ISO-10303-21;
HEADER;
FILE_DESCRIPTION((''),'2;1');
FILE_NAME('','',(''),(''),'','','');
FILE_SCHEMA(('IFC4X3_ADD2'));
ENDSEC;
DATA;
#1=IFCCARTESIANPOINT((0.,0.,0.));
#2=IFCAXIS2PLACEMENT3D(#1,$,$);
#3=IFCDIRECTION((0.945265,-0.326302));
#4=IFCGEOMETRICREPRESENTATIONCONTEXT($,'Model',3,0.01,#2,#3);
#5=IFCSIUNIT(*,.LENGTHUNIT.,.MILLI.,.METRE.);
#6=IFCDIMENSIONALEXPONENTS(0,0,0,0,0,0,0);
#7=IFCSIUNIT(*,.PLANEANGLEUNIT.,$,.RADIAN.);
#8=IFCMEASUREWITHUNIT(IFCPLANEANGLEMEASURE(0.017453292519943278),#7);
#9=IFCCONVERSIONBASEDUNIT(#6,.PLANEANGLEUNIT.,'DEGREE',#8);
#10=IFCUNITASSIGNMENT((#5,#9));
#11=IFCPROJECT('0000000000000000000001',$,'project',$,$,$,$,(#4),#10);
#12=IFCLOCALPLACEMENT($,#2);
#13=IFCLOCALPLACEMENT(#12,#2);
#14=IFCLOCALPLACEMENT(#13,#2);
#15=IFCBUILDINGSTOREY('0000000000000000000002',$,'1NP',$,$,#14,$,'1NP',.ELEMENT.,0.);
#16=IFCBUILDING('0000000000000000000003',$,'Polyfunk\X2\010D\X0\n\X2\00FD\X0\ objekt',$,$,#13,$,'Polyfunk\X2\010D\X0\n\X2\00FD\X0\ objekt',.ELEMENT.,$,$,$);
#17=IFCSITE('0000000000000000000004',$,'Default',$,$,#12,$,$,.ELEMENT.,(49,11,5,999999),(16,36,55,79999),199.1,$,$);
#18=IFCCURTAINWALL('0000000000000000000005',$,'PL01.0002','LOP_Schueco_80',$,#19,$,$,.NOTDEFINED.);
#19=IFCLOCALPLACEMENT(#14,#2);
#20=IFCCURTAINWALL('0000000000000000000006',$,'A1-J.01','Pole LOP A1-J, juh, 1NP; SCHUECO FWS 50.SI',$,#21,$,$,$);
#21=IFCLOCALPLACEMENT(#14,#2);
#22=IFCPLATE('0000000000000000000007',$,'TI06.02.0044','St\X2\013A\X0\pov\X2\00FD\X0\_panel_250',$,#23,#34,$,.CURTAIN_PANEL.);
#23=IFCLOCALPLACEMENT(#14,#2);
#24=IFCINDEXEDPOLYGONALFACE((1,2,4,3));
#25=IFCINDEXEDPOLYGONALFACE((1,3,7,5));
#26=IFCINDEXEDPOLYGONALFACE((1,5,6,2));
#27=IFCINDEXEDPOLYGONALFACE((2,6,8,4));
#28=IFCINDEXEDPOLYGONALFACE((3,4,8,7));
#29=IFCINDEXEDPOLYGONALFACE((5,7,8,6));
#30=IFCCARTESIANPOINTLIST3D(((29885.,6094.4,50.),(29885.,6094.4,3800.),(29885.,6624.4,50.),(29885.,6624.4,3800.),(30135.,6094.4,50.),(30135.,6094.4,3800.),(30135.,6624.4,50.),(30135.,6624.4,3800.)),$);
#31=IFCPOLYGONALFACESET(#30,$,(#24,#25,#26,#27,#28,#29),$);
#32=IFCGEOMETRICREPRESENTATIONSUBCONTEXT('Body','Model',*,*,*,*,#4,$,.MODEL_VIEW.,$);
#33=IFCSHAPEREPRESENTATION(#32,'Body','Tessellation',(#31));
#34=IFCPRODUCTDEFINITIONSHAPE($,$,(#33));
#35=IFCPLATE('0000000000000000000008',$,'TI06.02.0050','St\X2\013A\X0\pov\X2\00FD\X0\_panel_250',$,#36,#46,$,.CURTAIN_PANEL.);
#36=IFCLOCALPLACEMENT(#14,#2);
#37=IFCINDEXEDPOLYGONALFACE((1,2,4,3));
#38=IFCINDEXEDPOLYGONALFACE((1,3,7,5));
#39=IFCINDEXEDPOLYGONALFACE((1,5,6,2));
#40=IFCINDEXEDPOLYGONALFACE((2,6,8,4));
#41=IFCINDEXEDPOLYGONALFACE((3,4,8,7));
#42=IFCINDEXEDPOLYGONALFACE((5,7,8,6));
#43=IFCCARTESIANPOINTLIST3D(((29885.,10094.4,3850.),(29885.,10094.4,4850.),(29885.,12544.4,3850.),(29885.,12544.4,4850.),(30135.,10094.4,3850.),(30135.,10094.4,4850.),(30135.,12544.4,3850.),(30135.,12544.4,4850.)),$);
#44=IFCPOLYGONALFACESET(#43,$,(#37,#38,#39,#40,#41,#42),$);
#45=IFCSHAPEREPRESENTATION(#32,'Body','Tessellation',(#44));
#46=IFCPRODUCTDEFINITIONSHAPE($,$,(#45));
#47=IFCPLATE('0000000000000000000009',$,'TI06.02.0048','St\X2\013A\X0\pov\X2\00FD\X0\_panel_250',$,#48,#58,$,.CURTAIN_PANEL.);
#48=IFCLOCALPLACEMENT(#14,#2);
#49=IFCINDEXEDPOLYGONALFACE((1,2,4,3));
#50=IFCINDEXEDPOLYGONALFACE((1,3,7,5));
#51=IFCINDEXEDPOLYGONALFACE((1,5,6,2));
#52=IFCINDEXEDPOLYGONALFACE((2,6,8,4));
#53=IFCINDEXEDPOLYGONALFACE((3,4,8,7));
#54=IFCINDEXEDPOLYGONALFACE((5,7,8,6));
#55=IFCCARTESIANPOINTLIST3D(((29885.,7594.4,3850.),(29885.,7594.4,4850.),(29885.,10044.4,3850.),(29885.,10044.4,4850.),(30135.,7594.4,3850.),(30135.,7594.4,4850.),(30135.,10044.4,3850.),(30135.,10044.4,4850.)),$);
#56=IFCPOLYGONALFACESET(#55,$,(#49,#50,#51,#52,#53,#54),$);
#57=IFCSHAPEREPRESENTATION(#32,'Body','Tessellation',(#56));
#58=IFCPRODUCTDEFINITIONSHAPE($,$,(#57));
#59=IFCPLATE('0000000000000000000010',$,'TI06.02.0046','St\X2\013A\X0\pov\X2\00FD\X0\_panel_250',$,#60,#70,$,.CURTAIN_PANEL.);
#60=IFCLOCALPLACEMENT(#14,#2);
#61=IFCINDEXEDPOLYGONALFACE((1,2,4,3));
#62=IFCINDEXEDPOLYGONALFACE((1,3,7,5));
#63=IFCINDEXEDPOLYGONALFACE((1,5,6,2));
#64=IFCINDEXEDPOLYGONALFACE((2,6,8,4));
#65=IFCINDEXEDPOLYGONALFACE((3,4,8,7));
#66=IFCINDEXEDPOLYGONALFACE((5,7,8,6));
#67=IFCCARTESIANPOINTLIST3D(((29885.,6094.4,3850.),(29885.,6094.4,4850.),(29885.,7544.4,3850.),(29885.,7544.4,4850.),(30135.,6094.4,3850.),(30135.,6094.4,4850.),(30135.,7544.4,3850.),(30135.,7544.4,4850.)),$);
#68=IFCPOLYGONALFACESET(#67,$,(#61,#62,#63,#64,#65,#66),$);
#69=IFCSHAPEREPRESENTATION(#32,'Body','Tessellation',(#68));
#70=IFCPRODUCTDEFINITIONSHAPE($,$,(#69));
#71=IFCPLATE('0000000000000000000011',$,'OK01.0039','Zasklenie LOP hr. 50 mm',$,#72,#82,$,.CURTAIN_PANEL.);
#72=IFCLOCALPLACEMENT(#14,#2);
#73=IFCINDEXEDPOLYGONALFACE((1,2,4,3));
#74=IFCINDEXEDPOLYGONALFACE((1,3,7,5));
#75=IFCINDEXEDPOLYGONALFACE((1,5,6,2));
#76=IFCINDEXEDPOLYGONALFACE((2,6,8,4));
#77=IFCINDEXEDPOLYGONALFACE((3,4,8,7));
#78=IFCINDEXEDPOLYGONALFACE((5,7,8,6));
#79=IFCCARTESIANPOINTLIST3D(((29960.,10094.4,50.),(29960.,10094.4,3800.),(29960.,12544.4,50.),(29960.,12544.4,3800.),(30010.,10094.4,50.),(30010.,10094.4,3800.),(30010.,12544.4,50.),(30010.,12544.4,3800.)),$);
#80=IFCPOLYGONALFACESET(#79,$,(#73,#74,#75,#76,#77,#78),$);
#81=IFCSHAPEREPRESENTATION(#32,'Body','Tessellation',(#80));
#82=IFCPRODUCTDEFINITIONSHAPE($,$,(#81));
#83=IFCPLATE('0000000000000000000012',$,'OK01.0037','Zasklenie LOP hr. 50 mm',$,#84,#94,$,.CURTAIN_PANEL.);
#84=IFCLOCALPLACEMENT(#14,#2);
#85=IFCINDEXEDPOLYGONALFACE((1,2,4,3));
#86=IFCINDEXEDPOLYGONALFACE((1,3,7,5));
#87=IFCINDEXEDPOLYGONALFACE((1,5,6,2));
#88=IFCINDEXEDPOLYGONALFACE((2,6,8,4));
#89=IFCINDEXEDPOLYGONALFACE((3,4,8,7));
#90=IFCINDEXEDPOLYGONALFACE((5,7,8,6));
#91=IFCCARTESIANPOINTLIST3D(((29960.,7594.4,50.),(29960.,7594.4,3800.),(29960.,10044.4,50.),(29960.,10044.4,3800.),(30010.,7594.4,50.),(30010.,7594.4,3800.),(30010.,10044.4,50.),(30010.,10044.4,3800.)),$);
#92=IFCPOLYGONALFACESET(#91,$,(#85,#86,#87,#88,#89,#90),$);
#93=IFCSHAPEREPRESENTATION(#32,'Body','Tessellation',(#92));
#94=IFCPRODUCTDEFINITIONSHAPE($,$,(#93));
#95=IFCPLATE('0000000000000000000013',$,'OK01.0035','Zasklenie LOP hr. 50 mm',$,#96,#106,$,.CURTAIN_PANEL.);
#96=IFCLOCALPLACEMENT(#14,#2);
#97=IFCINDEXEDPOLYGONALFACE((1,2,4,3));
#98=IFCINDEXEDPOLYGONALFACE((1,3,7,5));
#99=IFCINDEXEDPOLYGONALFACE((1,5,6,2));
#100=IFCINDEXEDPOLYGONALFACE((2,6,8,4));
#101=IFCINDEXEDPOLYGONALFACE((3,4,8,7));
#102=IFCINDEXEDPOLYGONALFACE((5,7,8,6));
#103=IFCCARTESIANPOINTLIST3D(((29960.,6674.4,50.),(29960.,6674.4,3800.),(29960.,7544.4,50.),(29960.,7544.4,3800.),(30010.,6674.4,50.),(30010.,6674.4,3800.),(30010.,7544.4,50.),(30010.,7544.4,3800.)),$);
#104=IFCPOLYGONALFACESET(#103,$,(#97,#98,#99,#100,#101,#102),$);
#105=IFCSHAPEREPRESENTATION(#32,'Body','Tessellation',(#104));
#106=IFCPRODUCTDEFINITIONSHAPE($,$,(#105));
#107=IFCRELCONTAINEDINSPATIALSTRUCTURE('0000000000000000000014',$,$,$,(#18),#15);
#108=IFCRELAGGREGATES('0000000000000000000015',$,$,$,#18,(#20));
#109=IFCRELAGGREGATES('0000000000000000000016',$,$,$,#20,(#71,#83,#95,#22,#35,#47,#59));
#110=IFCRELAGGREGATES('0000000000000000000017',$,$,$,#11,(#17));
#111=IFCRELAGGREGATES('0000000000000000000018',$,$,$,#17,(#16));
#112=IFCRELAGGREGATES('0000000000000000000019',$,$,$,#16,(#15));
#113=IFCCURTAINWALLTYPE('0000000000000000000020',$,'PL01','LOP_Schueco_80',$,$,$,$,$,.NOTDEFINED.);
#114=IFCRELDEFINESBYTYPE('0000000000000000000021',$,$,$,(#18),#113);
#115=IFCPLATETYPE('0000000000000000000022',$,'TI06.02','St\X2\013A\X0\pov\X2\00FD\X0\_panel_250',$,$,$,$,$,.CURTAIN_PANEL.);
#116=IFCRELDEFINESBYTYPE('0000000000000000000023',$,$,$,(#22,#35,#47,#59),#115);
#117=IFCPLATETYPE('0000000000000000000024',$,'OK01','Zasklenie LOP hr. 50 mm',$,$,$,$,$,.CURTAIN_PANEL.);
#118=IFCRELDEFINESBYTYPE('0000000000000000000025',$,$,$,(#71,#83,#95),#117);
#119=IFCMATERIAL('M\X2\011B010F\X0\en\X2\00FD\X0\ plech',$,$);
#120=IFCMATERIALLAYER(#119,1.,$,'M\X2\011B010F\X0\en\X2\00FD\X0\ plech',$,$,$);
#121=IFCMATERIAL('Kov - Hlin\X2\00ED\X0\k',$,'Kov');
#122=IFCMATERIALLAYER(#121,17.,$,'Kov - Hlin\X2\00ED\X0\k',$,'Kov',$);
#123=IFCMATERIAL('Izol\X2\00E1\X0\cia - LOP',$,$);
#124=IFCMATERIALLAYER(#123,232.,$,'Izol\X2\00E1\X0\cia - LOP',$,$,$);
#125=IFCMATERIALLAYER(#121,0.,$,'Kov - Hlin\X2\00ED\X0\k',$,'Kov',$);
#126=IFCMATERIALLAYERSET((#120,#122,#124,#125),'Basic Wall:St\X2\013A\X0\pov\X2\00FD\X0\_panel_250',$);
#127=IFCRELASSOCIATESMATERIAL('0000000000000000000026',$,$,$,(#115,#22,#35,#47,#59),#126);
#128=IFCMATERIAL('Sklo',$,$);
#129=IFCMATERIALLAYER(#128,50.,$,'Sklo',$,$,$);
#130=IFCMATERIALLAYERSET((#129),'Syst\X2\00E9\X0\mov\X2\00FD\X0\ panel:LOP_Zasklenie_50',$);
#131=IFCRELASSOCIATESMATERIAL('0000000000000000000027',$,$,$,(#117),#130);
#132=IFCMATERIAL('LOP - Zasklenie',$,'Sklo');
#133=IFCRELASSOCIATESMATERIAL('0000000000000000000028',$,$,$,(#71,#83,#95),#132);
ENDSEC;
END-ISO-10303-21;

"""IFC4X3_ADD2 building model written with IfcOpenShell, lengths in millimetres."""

from ifc_helpers import new_model, entity, si_unit, converted_unit, direction, frame, frame_2d, origin, place, context, subcontext, project, spatial, rectangle, extrude, source, transform, mapped, material, layer, layer_set, layer_usage, type_object, type_shapes, element, aggregate, save


model = new_model("IFC4X3_ADD2")

# Units and contexts
model_context = context("Model", 3, precision=0.01, world=origin(), true_north=direction((0.945265, -0.326302)))
body_context = subcontext(model_context, "Body", "Model", "MODEL_VIEW")
ifc_project = project(units=[si_unit("LENGTHUNIT", "METRE", prefix="MILLI"), converted_unit("PLANEANGLEUNIT", "DEGREE", entity("IfcPlaneAngleMeasure", 0.017453292519943278), si_unit("PLANEANGLEUNIT", "RADIAN"), dimensions=[0, 0, 0, 0, 0, 0, 0])], contexts=[model_context])

# Site, building, storey
site_placement = place(None, origin())
site = spatial("IfcSite", under=ifc_project, at=site_placement, Name="Default", CompositionType="ELEMENT", RefLatitude=(49, 11, 5, 999999), RefLongitude=(16, 36, 55, 79999), RefElevation=199.1)
building_placement = place(site_placement, origin())
building = spatial("IfcBuilding", under=site, at=building_placement, Name="Polyfunkčný objekt", LongName="Polyfunkčný objekt", CompositionType="ELEMENT")
storey_placement = place(building_placement, origin())
storey = spatial("IfcBuildingStorey", under=building, at=storey_placement, Name="1NP", LongName="1NP", CompositionType="ELEMENT", Elevation=0.0)

# Curtain walls, plates
curtain_wall_type = type_object("IfcCurtainWallType", Name="PL01", Description="LOP_Schueco_80", PredefinedType="NOTDEFINED")
curtain_wall_1_placement = place(storey_placement, origin())
curtain_wall_1 = element("IfcCurtainWall", 1, at=curtain_wall_1_placement, inside=storey, type_object=curtain_wall_type, Name="PL01.0002", Description="LOP_Schueco_80", PredefinedType="NOTDEFINED")
curtain_wall_2 = element("IfcCurtainWall", 2, Name="A1-J.01", Description="Pole LOP A1-J, juh, 1NP; SCHUECO FWS 50.SI")
aggregate(curtain_wall_1, [curtain_wall_2])
ifc_material_1 = material(Name="Měďený plech")
ifc_layer_1 = layer(ifc_material_1, 1.0, Name="Měďený plech")
ifc_material_2 = material(Name="Kov - Hliník", Category="Kov")
ifc_layer_2 = layer(ifc_material_2, 17.0, Name="Kov - Hliník", Category="Kov")
ifc_material_3 = material(Name="Izolácia - LOP")
ifc_layer_3 = layer(ifc_material_3, 232.0, Name="Izolácia - LOP")
ifc_layer_4 = layer(ifc_material_2, 0.0, Name="Kov - Hliník", Category="Kov")
ifc_layer_set_1 = layer_set([ifc_layer_1, ifc_layer_2, ifc_layer_3, ifc_layer_4], Name="Basic Wall:Stĺpový_panel_250")
ifc_layer_usage_1 = layer_usage(ifc_layer_set_1, "AXIS2", "POSITIVE", -125.0)
plate_type_1 = type_object("IfcPlateType", Name="TI06.02", Description="Stĺpový_panel_250", PredefinedType="CURTAIN_PANEL", material=ifc_layer_set_1)
plate_1_placement = place(storey_placement, frame((30010.0, 6624.4, 50.0), z_axis=(0.0, 0.0, 1.0), x_axis=(0.0, -1.0, 0.0)))
plate_1 = element("IfcPlate", 3, at=plate_1_placement, type_object=plate_type_1, material=ifc_layer_usage_1, Name="TI06.02.0044", Description="Stĺpový_panel_250", PredefinedType="CURTAIN_PANEL", context=body_context, shape_type="SweptSolid", body=[
    extrude(rectangle(XDim=250.0, YDim=530.0, at=frame_2d((0.0, 0.0), x_axis=(1.0, 0.0))), frame((265.0, 0.0, 0.0), z_axis=(0.0, 0.0, 1.0), x_axis=(0.0, 1.0, 0.0)), (0.0, 0.0, 1.0), 3750.0),
])
ifc_layer_usage_2 = layer_usage(ifc_layer_set_1, "AXIS2", "POSITIVE", -125.0)
plate_2_placement = place(storey_placement, frame((30010.0, 12544.4, 3850.0), z_axis=(0.0, 0.0, 1.0), x_axis=(0.0, -1.0, 0.0)))
plate_2 = element("IfcPlate", 4, at=plate_2_placement, type_object=plate_type_1, material=ifc_layer_usage_2, Name="TI06.02.0050", Description="Stĺpový_panel_250", PredefinedType="CURTAIN_PANEL", context=body_context, shape_type="SweptSolid", body=[
    extrude(rectangle(XDim=250.0, YDim=2450.0, at=frame_2d((0.0, 0.0), x_axis=(1.0, 0.0))), frame((1225.0, 0.0, 0.0), z_axis=(0.0, 0.0, 1.0), x_axis=(0.0, 1.0, 0.0)), (0.0, 0.0, 1.0), 1000.0),
])
ifc_layer_usage_3 = layer_usage(ifc_layer_set_1, "AXIS2", "POSITIVE", -125.0)
plate_3_placement = place(storey_placement, frame((30010.0, 10044.4, 3850.0), z_axis=(0.0, 0.0, 1.0), x_axis=(0.0, -1.0, 0.0)))
plate_3 = element("IfcPlate", 5, at=plate_3_placement, type_object=plate_type_1, material=ifc_layer_usage_3, Name="TI06.02.0048", Description="Stĺpový_panel_250", PredefinedType="CURTAIN_PANEL", context=body_context, shape_type="SweptSolid", body=[
    extrude(rectangle(XDim=250.0, YDim=2450.0, at=frame_2d((0.0, 0.0), x_axis=(1.0, 0.0))), frame((1225.0, 0.0, 0.0), z_axis=(0.0, 0.0, 1.0), x_axis=(0.0, 1.0, 0.0)), (0.0, 0.0, 1.0), 1000.0),
])
ifc_layer_usage_4 = layer_usage(ifc_layer_set_1, "AXIS2", "POSITIVE", -125.0)
plate_4_placement = place(storey_placement, frame((30010.0, 7544.4, 3850.0), z_axis=(0.0, 0.0, 1.0), x_axis=(0.0, -1.0, 0.0)))
plate_4 = element("IfcPlate", 6, at=plate_4_placement, type_object=plate_type_1, material=ifc_layer_usage_4, Name="TI06.02.0046", Description="Stĺpový_panel_250", PredefinedType="CURTAIN_PANEL", context=body_context, shape_type="SweptSolid", body=[
    extrude(rectangle(XDim=250.0, YDim=1450.0, at=frame_2d((0.0, 0.0), x_axis=(1.0, 0.0))), frame((725.0, 0.0, 0.0), z_axis=(0.0, 0.0, 1.0), x_axis=(0.0, 1.0, 0.0)), (0.0, 0.0, 1.0), 1000.0),
])
ifc_material_4 = material(Name="LOP - Zasklenie", Category="Sklo")
ifc_material_5 = material(Name="Sklo")
ifc_layer_5 = layer(ifc_material_5, 50.0, Name="Sklo")
ifc_layer_set_2 = layer_set([ifc_layer_5], Name="Systémový panel:LOP_Zasklenie_50")
plate_type_2 = type_object("IfcPlateType", Name="OK01", Description="Zasklenie LOP hr. 50 mm", PredefinedType="CURTAIN_PANEL", material=ifc_layer_set_2)
shared_shape_1 = source(origin(), body_context, "Body", "SweptSolid", [
    extrude(rectangle(XDim=3750.0, YDim=2450.0, at=frame_2d((-141.7, 0.0), x_axis=(1.0, 0.0))), frame((0.0, -50.0, 2016.7), z_axis=(0.0, 1.0, 0.0), x_axis=(0.0, 0.0, 1.0)), (0.0, 0.0, 1.0), 50.0),
])
plate_5_placement = place(curtain_wall_1_placement, frame((30010.0, 11319.4, 50.0), z_axis=(0.0, 0.0, 1.0), x_axis=(0.0, -1.0, 0.0)))
plate_5 = element("IfcPlate", 7, at=plate_5_placement, type_object=plate_type_2, material=ifc_material_4, Name="OK01.0039", Description="Zasklenie LOP hr. 50 mm", PredefinedType="CURTAIN_PANEL", context=body_context, shape_type="MappedRepresentation", body=[
    mapped(shared_shape_1, transform((0.0, 0.0, 0.0), scale=1.0)),
])
plate_6_placement = place(curtain_wall_1_placement, frame((30010.0, 8819.4, 50.0), z_axis=(0.0, 0.0, 1.0), x_axis=(0.0, -1.0, 0.0)))
plate_6 = element("IfcPlate", 8, at=plate_6_placement, type_object=plate_type_2, material=ifc_material_4, Name="OK01.0037", Description="Zasklenie LOP hr. 50 mm", PredefinedType="CURTAIN_PANEL", context=body_context, shape_type="MappedRepresentation", body=[
    mapped(shared_shape_1, transform((0.0, 0.0, 0.0), scale=1.0)),
])
shared_shape_2 = source(origin(), body_context, "Body", "SweptSolid", [
    extrude(rectangle(XDim=3750.0, YDim=870.0, at=frame_2d((-141.7, 0.0), x_axis=(1.0, 0.0))), frame((0.0, -50.0, 2016.7), z_axis=(0.0, 1.0, 0.0), x_axis=(0.0, 0.0, 1.0)), (0.0, 0.0, 1.0), 50.0),
])
type_shapes(plate_type_2, [shared_shape_1, shared_shape_2])
plate_7_placement = place(curtain_wall_1_placement, frame((30010.0, 7109.4, 50.0), z_axis=(0.0, 0.0, 1.0), x_axis=(0.0, -1.0, 0.0)))
plate_7 = element("IfcPlate", 9, at=plate_7_placement, type_object=plate_type_2, material=ifc_material_4, Name="OK01.0035", Description="Zasklenie LOP hr. 50 mm", PredefinedType="CURTAIN_PANEL", context=body_context, shape_type="MappedRepresentation", body=[
    mapped(shared_shape_2, transform((0.0, 0.0, 0.0), scale=1.0)),
])
aggregate(curtain_wall_2, [plate_5, plate_6, plate_7, plate_1, plate_2, plate_3, plate_4])

save(model, "model.ifc")
